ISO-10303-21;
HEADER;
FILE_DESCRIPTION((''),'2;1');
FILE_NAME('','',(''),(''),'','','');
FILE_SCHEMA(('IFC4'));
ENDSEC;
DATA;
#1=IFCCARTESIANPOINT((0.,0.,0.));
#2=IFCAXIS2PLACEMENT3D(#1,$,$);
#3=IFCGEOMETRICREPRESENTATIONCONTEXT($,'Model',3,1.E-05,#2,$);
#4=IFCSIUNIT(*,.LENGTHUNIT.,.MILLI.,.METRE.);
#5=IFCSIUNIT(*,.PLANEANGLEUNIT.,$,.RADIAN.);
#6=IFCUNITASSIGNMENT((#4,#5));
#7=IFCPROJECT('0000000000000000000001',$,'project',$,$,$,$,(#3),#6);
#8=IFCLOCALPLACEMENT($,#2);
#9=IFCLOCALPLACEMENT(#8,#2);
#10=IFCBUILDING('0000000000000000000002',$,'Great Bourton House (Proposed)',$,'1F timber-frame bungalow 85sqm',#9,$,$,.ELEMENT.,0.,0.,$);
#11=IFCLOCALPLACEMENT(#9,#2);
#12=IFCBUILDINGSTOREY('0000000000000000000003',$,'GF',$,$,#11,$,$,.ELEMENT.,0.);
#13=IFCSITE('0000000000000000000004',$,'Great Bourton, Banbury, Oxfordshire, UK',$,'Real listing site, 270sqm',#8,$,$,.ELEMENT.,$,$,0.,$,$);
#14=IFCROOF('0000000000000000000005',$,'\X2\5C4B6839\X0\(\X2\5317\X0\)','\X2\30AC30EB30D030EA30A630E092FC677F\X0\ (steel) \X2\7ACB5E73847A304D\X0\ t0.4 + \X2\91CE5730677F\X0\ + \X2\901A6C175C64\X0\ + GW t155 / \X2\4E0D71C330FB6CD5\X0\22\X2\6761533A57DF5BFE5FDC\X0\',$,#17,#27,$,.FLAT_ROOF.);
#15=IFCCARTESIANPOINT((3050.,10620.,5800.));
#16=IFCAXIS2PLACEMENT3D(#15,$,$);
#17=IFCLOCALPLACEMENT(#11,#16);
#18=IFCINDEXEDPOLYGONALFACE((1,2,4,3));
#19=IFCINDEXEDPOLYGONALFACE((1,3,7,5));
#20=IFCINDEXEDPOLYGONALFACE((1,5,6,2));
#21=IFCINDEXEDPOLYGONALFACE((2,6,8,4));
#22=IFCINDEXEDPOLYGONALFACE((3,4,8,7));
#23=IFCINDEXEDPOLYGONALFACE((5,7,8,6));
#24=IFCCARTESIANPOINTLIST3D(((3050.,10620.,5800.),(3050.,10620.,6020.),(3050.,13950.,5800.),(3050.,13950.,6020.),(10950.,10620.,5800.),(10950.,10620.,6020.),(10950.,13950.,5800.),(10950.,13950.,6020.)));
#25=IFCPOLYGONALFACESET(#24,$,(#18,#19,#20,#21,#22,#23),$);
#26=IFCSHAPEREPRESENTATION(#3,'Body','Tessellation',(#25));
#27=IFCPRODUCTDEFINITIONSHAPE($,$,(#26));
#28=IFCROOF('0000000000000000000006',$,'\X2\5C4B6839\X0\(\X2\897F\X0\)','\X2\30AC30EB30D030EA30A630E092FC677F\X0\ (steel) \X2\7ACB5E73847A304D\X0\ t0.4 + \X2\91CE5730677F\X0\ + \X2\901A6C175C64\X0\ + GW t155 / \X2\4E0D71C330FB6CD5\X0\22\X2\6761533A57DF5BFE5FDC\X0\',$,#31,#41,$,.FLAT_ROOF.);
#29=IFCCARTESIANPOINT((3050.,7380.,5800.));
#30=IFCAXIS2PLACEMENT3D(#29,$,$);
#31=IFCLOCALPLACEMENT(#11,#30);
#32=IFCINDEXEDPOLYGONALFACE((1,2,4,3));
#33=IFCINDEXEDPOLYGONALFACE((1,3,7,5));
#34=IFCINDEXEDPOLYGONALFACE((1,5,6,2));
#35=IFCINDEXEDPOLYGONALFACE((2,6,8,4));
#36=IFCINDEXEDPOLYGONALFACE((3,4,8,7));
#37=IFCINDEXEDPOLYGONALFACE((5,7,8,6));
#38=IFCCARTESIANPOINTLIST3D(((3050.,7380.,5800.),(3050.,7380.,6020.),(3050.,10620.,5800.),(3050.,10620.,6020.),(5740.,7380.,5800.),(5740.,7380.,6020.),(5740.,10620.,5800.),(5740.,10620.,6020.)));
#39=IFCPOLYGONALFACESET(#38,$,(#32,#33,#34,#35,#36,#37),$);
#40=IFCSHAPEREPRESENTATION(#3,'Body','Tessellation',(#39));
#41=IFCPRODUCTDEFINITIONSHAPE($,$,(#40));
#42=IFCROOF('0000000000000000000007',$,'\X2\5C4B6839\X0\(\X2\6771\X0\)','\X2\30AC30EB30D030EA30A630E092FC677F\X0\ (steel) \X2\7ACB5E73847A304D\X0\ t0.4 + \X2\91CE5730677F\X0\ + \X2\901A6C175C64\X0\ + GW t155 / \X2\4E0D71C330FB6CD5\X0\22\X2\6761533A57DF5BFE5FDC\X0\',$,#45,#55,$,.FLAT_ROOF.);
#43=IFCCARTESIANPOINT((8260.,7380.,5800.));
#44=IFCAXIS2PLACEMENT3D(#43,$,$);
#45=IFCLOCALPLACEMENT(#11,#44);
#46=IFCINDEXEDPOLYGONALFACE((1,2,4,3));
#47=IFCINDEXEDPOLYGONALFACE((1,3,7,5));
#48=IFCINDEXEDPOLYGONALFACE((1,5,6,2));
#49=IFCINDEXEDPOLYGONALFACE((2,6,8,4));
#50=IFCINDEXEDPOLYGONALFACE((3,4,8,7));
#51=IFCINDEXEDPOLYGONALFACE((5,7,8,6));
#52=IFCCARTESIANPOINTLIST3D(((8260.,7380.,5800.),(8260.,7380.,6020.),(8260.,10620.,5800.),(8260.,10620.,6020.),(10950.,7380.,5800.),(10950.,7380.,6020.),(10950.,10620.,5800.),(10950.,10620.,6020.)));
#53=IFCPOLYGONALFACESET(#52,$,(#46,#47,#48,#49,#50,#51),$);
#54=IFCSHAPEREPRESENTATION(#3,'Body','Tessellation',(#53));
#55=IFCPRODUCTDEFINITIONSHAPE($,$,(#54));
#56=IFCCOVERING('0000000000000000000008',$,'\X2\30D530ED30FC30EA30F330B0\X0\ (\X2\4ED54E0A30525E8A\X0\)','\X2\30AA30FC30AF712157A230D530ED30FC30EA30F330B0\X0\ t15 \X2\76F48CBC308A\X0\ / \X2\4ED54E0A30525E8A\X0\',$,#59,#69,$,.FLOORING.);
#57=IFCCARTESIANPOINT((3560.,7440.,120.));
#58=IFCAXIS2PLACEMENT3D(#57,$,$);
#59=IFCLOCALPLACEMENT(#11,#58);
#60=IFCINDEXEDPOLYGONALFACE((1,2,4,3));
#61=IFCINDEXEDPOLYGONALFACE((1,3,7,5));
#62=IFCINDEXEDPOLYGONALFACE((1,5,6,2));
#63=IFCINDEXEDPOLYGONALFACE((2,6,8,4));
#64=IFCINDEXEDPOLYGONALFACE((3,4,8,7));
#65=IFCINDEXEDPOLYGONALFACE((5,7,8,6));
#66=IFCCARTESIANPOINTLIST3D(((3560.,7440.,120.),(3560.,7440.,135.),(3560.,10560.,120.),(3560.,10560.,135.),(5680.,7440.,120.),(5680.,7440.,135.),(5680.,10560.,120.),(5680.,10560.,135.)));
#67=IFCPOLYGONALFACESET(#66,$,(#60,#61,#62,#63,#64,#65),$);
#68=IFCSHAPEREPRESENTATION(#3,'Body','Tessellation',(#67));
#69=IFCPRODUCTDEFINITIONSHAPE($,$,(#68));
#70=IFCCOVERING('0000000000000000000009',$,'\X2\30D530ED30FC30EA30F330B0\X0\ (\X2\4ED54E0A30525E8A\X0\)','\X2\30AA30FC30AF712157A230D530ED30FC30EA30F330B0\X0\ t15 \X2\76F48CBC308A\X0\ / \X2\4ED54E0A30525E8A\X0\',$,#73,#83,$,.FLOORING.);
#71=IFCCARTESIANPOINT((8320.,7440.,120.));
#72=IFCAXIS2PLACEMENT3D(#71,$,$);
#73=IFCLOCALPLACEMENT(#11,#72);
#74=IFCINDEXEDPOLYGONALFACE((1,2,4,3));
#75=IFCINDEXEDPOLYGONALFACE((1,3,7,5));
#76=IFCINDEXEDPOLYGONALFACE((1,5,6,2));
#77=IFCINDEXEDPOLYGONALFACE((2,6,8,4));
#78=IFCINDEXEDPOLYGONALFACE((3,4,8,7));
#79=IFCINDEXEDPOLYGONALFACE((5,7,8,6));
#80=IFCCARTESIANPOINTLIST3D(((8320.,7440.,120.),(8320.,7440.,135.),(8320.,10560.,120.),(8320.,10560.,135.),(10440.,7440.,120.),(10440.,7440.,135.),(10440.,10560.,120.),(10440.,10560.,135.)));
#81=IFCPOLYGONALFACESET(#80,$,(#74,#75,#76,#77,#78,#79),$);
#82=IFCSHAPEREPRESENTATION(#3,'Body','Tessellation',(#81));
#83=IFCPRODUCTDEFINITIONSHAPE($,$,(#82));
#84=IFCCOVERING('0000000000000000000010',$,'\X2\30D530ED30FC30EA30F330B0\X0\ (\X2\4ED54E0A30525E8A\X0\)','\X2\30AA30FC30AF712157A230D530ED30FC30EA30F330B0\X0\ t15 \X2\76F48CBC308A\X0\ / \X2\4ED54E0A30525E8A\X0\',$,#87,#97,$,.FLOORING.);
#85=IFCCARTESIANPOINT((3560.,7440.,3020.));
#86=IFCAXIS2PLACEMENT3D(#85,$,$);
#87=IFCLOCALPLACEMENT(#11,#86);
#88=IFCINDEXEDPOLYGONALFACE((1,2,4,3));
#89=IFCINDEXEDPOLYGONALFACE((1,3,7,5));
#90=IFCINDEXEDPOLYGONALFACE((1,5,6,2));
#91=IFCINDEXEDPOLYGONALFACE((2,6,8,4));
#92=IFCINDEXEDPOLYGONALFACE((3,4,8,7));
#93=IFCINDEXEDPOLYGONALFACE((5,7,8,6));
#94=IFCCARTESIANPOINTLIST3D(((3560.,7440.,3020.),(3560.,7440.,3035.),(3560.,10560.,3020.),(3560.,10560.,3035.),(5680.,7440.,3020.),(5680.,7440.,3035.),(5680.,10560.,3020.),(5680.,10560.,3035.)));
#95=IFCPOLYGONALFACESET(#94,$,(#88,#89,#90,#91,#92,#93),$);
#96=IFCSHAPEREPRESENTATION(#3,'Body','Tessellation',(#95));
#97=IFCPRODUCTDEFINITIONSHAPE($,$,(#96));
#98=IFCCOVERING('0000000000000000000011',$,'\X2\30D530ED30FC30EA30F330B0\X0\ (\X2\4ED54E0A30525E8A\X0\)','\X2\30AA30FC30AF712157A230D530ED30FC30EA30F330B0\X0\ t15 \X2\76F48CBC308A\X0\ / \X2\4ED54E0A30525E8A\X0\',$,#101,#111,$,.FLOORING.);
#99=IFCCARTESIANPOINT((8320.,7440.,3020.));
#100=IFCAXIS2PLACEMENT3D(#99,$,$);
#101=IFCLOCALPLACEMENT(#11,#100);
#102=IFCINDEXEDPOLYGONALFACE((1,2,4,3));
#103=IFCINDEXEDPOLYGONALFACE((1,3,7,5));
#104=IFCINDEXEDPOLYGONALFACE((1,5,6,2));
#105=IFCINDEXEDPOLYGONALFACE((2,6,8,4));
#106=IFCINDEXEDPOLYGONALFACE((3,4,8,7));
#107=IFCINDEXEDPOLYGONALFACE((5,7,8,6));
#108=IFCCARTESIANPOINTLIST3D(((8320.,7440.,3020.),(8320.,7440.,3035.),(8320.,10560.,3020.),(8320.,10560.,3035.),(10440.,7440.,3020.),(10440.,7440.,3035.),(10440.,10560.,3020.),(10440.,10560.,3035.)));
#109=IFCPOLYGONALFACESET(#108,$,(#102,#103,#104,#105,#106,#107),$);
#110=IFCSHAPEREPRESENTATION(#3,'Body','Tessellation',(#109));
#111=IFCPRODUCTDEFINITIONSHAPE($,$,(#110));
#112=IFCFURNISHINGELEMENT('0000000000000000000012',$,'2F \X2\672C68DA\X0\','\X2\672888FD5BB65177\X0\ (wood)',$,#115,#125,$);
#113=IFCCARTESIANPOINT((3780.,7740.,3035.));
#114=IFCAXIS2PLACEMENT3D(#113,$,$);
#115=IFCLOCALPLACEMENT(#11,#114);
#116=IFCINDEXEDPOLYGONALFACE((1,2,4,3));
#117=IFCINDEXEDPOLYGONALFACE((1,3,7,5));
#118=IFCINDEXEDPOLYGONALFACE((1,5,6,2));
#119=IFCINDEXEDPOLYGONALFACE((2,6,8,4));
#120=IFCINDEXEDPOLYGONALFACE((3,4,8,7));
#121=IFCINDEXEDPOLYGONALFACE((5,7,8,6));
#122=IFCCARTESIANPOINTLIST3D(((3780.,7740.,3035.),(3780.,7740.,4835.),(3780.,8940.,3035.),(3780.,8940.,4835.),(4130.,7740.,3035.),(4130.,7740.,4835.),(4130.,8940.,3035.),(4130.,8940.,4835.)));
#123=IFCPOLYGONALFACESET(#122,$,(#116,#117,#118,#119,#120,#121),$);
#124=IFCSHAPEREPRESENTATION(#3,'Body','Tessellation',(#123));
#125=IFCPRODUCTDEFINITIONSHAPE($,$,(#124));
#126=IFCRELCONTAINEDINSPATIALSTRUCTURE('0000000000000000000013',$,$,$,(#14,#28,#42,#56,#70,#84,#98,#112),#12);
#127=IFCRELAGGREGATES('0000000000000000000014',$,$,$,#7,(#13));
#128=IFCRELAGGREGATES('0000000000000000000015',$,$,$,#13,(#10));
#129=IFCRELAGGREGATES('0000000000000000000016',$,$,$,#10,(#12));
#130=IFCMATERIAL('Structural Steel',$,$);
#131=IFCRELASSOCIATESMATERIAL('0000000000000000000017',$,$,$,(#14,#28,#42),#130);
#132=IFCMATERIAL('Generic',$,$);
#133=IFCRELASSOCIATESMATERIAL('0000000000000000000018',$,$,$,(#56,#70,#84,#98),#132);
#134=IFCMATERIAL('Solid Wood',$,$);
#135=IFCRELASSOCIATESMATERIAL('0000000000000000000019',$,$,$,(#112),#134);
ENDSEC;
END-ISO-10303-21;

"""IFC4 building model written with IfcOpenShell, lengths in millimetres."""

from ifc_helpers import new_model, si_unit, frame, frame_2d, origin, place, context, project, spatial, rectangle, extrude, material, element, save


model = new_model("IFC4")

# Units and contexts
model_context = context("Model", 3, precision=1e-05, world=origin())
ifc_project = project(units=[si_unit("LENGTHUNIT", "METRE", prefix="MILLI"), si_unit("PLANEANGLEUNIT", "RADIAN")], contexts=[model_context])

# Site, building, storey
site_placement = place(None, origin())
site = spatial("IfcSite", under=ifc_project, at=site_placement, Name="Great Bourton, Banbury, Oxfordshire, UK", ObjectType="Real listing site, 270sqm", CompositionType="ELEMENT", RefElevation=0.0)
building_placement = place(site_placement, origin())
building = spatial("IfcBuilding", under=site, at=building_placement, Name="Great Bourton House (Proposed)", ObjectType="1F timber-frame bungalow 85sqm", CompositionType="ELEMENT", ElevationOfRefHeight=0.0, ElevationOfTerrain=0.0)
storey_placement = place(building_placement, origin())
storey = spatial("IfcBuildingStorey", under=building, at=storey_placement, Name="GF", CompositionType="ELEMENT", Elevation=0.0)

# Shared definitions
ifc_material_1 = material(Name="Solid Wood")

# Shared definitions
ifc_material_2 = material(Name="Generic")

# Roofs
ifc_material_3 = material(Name="Structural Steel")
roof_1_placement = place(storey_placement, frame((3050.0, 10620.0, 5800.0)))
element("IfcRoof", 1, at=roof_1_placement, inside=storey, material=ifc_material_3, Name="屋根(北)", Description="ガルバリウム鋼板 (steel) 立平葺き t0.4 + 野地板 + 通気層 + GW t155 / 不燃・法22条区域対応", PredefinedType="FLAT_ROOF", context=model_context, shape_type="SweptSolid", body=[
    extrude(rectangle(XDim=7900.0, YDim=3330.0, at=frame_2d((3950.0, 1665.0))), frame((3050.0, 10620.0, 5800.0)), (0.0, 0.0, 1.0), 220.0),
])
roof_2_placement = place(storey_placement, frame((3050.0, 7380.0, 5800.0)))
element("IfcRoof", 2, at=roof_2_placement, inside=storey, material=ifc_material_3, Name="屋根(西)", Description="ガルバリウム鋼板 (steel) 立平葺き t0.4 + 野地板 + 通気層 + GW t155 / 不燃・法22条区域対応", PredefinedType="FLAT_ROOF", context=model_context, shape_type="SweptSolid", body=[
    extrude(rectangle(XDim=2690.0, YDim=3240.0, at=frame_2d((1345.0, 1620.0))), frame((3050.0, 7380.0, 5800.0)), (0.0, 0.0, 1.0), 220.0),
])
roof_3_placement = place(storey_placement, frame((8260.0, 7380.0, 5800.0)))
element("IfcRoof", 3, at=roof_3_placement, inside=storey, material=ifc_material_3, Name="屋根(東)", Description="ガルバリウム鋼板 (steel) 立平葺き t0.4 + 野地板 + 通気層 + GW t155 / 不燃・法22条区域対応", PredefinedType="FLAT_ROOF", context=model_context, shape_type="SweptSolid", body=[
    extrude(rectangle(XDim=2690.0, YDim=3240.0, at=frame_2d((1345.0, 1620.0))), frame((8260.0, 7380.0, 5800.0)), (0.0, 0.0, 1.0), 220.0),
])

# Coverings
covering_1_placement = place(storey_placement, frame((3560.0, 7440.0, 120.0)))
element("IfcCovering", 4, at=covering_1_placement, inside=storey, material=ifc_material_2, Name="フローリング (仕上げ床)", Description="オーク無垢フローリング t15 直貼り / 仕上げ床", PredefinedType="FLOORING", context=model_context, shape_type="SweptSolid", body=[
    extrude(rectangle(XDim=2120.0, YDim=3120.0, at=frame_2d((1060.0, 1560.0))), frame((3560.0, 7440.0, 120.0)), (0.0, 0.0, 1.0), 15.0),
])
covering_2_placement = place(storey_placement, frame((8320.0, 7440.0, 120.0)))
element("IfcCovering", 5, at=covering_2_placement, inside=storey, material=ifc_material_2, Name="フローリング (仕上げ床)", Description="オーク無垢フローリング t15 直貼り / 仕上げ床", PredefinedType="FLOORING", context=model_context, shape_type="SweptSolid", body=[
    extrude(rectangle(XDim=2120.0, YDim=3120.0, at=frame_2d((1060.0, 1560.0))), frame((8320.0, 7440.0, 120.0)), (0.0, 0.0, 1.0), 15.0),
])
covering_3_placement = place(storey_placement, frame((3560.0, 7440.0, 3020.0)))
element("IfcCovering", 6, at=covering_3_placement, inside=storey, material=ifc_material_2, Name="フローリング (仕上げ床)", Description="オーク無垢フローリング t15 直貼り / 仕上げ床", PredefinedType="FLOORING", context=model_context, shape_type="SweptSolid", body=[
    extrude(rectangle(XDim=2120.0, YDim=3120.0, at=frame_2d((1060.0, 1560.0))), frame((3560.0, 7440.0, 3020.0)), (0.0, 0.0, 1.0), 15.0),
])
covering_4_placement = place(storey_placement, frame((8320.0, 7440.0, 3020.0)))
element("IfcCovering", 7, at=covering_4_placement, inside=storey, material=ifc_material_2, Name="フローリング (仕上げ床)", Description="オーク無垢フローリング t15 直貼り / 仕上げ床", PredefinedType="FLOORING", context=model_context, shape_type="SweptSolid", body=[
    extrude(rectangle(XDim=2120.0, YDim=3120.0, at=frame_2d((1060.0, 1560.0))), frame((8320.0, 7440.0, 3020.0)), (0.0, 0.0, 1.0), 15.0),
])

# Furnishing element
furnishing_placement = place(storey_placement, frame((3780.0, 7740.0, 3035.0)))
element("IfcFurnishingElement", 8, at=furnishing_placement, inside=storey, material=ifc_material_1, Name="2F 本棚", Description="木製家具 (wood)", context=model_context, shape_type="SweptSolid", body=[
    extrude(rectangle(XDim=350.0, YDim=1200.0, at=frame_2d((175.0, 600.0))), frame((3780.0, 7740.0, 3035.0)), (0.0, 0.0, 1.0), 1800.0),
])

save(model, "model.ifc")
